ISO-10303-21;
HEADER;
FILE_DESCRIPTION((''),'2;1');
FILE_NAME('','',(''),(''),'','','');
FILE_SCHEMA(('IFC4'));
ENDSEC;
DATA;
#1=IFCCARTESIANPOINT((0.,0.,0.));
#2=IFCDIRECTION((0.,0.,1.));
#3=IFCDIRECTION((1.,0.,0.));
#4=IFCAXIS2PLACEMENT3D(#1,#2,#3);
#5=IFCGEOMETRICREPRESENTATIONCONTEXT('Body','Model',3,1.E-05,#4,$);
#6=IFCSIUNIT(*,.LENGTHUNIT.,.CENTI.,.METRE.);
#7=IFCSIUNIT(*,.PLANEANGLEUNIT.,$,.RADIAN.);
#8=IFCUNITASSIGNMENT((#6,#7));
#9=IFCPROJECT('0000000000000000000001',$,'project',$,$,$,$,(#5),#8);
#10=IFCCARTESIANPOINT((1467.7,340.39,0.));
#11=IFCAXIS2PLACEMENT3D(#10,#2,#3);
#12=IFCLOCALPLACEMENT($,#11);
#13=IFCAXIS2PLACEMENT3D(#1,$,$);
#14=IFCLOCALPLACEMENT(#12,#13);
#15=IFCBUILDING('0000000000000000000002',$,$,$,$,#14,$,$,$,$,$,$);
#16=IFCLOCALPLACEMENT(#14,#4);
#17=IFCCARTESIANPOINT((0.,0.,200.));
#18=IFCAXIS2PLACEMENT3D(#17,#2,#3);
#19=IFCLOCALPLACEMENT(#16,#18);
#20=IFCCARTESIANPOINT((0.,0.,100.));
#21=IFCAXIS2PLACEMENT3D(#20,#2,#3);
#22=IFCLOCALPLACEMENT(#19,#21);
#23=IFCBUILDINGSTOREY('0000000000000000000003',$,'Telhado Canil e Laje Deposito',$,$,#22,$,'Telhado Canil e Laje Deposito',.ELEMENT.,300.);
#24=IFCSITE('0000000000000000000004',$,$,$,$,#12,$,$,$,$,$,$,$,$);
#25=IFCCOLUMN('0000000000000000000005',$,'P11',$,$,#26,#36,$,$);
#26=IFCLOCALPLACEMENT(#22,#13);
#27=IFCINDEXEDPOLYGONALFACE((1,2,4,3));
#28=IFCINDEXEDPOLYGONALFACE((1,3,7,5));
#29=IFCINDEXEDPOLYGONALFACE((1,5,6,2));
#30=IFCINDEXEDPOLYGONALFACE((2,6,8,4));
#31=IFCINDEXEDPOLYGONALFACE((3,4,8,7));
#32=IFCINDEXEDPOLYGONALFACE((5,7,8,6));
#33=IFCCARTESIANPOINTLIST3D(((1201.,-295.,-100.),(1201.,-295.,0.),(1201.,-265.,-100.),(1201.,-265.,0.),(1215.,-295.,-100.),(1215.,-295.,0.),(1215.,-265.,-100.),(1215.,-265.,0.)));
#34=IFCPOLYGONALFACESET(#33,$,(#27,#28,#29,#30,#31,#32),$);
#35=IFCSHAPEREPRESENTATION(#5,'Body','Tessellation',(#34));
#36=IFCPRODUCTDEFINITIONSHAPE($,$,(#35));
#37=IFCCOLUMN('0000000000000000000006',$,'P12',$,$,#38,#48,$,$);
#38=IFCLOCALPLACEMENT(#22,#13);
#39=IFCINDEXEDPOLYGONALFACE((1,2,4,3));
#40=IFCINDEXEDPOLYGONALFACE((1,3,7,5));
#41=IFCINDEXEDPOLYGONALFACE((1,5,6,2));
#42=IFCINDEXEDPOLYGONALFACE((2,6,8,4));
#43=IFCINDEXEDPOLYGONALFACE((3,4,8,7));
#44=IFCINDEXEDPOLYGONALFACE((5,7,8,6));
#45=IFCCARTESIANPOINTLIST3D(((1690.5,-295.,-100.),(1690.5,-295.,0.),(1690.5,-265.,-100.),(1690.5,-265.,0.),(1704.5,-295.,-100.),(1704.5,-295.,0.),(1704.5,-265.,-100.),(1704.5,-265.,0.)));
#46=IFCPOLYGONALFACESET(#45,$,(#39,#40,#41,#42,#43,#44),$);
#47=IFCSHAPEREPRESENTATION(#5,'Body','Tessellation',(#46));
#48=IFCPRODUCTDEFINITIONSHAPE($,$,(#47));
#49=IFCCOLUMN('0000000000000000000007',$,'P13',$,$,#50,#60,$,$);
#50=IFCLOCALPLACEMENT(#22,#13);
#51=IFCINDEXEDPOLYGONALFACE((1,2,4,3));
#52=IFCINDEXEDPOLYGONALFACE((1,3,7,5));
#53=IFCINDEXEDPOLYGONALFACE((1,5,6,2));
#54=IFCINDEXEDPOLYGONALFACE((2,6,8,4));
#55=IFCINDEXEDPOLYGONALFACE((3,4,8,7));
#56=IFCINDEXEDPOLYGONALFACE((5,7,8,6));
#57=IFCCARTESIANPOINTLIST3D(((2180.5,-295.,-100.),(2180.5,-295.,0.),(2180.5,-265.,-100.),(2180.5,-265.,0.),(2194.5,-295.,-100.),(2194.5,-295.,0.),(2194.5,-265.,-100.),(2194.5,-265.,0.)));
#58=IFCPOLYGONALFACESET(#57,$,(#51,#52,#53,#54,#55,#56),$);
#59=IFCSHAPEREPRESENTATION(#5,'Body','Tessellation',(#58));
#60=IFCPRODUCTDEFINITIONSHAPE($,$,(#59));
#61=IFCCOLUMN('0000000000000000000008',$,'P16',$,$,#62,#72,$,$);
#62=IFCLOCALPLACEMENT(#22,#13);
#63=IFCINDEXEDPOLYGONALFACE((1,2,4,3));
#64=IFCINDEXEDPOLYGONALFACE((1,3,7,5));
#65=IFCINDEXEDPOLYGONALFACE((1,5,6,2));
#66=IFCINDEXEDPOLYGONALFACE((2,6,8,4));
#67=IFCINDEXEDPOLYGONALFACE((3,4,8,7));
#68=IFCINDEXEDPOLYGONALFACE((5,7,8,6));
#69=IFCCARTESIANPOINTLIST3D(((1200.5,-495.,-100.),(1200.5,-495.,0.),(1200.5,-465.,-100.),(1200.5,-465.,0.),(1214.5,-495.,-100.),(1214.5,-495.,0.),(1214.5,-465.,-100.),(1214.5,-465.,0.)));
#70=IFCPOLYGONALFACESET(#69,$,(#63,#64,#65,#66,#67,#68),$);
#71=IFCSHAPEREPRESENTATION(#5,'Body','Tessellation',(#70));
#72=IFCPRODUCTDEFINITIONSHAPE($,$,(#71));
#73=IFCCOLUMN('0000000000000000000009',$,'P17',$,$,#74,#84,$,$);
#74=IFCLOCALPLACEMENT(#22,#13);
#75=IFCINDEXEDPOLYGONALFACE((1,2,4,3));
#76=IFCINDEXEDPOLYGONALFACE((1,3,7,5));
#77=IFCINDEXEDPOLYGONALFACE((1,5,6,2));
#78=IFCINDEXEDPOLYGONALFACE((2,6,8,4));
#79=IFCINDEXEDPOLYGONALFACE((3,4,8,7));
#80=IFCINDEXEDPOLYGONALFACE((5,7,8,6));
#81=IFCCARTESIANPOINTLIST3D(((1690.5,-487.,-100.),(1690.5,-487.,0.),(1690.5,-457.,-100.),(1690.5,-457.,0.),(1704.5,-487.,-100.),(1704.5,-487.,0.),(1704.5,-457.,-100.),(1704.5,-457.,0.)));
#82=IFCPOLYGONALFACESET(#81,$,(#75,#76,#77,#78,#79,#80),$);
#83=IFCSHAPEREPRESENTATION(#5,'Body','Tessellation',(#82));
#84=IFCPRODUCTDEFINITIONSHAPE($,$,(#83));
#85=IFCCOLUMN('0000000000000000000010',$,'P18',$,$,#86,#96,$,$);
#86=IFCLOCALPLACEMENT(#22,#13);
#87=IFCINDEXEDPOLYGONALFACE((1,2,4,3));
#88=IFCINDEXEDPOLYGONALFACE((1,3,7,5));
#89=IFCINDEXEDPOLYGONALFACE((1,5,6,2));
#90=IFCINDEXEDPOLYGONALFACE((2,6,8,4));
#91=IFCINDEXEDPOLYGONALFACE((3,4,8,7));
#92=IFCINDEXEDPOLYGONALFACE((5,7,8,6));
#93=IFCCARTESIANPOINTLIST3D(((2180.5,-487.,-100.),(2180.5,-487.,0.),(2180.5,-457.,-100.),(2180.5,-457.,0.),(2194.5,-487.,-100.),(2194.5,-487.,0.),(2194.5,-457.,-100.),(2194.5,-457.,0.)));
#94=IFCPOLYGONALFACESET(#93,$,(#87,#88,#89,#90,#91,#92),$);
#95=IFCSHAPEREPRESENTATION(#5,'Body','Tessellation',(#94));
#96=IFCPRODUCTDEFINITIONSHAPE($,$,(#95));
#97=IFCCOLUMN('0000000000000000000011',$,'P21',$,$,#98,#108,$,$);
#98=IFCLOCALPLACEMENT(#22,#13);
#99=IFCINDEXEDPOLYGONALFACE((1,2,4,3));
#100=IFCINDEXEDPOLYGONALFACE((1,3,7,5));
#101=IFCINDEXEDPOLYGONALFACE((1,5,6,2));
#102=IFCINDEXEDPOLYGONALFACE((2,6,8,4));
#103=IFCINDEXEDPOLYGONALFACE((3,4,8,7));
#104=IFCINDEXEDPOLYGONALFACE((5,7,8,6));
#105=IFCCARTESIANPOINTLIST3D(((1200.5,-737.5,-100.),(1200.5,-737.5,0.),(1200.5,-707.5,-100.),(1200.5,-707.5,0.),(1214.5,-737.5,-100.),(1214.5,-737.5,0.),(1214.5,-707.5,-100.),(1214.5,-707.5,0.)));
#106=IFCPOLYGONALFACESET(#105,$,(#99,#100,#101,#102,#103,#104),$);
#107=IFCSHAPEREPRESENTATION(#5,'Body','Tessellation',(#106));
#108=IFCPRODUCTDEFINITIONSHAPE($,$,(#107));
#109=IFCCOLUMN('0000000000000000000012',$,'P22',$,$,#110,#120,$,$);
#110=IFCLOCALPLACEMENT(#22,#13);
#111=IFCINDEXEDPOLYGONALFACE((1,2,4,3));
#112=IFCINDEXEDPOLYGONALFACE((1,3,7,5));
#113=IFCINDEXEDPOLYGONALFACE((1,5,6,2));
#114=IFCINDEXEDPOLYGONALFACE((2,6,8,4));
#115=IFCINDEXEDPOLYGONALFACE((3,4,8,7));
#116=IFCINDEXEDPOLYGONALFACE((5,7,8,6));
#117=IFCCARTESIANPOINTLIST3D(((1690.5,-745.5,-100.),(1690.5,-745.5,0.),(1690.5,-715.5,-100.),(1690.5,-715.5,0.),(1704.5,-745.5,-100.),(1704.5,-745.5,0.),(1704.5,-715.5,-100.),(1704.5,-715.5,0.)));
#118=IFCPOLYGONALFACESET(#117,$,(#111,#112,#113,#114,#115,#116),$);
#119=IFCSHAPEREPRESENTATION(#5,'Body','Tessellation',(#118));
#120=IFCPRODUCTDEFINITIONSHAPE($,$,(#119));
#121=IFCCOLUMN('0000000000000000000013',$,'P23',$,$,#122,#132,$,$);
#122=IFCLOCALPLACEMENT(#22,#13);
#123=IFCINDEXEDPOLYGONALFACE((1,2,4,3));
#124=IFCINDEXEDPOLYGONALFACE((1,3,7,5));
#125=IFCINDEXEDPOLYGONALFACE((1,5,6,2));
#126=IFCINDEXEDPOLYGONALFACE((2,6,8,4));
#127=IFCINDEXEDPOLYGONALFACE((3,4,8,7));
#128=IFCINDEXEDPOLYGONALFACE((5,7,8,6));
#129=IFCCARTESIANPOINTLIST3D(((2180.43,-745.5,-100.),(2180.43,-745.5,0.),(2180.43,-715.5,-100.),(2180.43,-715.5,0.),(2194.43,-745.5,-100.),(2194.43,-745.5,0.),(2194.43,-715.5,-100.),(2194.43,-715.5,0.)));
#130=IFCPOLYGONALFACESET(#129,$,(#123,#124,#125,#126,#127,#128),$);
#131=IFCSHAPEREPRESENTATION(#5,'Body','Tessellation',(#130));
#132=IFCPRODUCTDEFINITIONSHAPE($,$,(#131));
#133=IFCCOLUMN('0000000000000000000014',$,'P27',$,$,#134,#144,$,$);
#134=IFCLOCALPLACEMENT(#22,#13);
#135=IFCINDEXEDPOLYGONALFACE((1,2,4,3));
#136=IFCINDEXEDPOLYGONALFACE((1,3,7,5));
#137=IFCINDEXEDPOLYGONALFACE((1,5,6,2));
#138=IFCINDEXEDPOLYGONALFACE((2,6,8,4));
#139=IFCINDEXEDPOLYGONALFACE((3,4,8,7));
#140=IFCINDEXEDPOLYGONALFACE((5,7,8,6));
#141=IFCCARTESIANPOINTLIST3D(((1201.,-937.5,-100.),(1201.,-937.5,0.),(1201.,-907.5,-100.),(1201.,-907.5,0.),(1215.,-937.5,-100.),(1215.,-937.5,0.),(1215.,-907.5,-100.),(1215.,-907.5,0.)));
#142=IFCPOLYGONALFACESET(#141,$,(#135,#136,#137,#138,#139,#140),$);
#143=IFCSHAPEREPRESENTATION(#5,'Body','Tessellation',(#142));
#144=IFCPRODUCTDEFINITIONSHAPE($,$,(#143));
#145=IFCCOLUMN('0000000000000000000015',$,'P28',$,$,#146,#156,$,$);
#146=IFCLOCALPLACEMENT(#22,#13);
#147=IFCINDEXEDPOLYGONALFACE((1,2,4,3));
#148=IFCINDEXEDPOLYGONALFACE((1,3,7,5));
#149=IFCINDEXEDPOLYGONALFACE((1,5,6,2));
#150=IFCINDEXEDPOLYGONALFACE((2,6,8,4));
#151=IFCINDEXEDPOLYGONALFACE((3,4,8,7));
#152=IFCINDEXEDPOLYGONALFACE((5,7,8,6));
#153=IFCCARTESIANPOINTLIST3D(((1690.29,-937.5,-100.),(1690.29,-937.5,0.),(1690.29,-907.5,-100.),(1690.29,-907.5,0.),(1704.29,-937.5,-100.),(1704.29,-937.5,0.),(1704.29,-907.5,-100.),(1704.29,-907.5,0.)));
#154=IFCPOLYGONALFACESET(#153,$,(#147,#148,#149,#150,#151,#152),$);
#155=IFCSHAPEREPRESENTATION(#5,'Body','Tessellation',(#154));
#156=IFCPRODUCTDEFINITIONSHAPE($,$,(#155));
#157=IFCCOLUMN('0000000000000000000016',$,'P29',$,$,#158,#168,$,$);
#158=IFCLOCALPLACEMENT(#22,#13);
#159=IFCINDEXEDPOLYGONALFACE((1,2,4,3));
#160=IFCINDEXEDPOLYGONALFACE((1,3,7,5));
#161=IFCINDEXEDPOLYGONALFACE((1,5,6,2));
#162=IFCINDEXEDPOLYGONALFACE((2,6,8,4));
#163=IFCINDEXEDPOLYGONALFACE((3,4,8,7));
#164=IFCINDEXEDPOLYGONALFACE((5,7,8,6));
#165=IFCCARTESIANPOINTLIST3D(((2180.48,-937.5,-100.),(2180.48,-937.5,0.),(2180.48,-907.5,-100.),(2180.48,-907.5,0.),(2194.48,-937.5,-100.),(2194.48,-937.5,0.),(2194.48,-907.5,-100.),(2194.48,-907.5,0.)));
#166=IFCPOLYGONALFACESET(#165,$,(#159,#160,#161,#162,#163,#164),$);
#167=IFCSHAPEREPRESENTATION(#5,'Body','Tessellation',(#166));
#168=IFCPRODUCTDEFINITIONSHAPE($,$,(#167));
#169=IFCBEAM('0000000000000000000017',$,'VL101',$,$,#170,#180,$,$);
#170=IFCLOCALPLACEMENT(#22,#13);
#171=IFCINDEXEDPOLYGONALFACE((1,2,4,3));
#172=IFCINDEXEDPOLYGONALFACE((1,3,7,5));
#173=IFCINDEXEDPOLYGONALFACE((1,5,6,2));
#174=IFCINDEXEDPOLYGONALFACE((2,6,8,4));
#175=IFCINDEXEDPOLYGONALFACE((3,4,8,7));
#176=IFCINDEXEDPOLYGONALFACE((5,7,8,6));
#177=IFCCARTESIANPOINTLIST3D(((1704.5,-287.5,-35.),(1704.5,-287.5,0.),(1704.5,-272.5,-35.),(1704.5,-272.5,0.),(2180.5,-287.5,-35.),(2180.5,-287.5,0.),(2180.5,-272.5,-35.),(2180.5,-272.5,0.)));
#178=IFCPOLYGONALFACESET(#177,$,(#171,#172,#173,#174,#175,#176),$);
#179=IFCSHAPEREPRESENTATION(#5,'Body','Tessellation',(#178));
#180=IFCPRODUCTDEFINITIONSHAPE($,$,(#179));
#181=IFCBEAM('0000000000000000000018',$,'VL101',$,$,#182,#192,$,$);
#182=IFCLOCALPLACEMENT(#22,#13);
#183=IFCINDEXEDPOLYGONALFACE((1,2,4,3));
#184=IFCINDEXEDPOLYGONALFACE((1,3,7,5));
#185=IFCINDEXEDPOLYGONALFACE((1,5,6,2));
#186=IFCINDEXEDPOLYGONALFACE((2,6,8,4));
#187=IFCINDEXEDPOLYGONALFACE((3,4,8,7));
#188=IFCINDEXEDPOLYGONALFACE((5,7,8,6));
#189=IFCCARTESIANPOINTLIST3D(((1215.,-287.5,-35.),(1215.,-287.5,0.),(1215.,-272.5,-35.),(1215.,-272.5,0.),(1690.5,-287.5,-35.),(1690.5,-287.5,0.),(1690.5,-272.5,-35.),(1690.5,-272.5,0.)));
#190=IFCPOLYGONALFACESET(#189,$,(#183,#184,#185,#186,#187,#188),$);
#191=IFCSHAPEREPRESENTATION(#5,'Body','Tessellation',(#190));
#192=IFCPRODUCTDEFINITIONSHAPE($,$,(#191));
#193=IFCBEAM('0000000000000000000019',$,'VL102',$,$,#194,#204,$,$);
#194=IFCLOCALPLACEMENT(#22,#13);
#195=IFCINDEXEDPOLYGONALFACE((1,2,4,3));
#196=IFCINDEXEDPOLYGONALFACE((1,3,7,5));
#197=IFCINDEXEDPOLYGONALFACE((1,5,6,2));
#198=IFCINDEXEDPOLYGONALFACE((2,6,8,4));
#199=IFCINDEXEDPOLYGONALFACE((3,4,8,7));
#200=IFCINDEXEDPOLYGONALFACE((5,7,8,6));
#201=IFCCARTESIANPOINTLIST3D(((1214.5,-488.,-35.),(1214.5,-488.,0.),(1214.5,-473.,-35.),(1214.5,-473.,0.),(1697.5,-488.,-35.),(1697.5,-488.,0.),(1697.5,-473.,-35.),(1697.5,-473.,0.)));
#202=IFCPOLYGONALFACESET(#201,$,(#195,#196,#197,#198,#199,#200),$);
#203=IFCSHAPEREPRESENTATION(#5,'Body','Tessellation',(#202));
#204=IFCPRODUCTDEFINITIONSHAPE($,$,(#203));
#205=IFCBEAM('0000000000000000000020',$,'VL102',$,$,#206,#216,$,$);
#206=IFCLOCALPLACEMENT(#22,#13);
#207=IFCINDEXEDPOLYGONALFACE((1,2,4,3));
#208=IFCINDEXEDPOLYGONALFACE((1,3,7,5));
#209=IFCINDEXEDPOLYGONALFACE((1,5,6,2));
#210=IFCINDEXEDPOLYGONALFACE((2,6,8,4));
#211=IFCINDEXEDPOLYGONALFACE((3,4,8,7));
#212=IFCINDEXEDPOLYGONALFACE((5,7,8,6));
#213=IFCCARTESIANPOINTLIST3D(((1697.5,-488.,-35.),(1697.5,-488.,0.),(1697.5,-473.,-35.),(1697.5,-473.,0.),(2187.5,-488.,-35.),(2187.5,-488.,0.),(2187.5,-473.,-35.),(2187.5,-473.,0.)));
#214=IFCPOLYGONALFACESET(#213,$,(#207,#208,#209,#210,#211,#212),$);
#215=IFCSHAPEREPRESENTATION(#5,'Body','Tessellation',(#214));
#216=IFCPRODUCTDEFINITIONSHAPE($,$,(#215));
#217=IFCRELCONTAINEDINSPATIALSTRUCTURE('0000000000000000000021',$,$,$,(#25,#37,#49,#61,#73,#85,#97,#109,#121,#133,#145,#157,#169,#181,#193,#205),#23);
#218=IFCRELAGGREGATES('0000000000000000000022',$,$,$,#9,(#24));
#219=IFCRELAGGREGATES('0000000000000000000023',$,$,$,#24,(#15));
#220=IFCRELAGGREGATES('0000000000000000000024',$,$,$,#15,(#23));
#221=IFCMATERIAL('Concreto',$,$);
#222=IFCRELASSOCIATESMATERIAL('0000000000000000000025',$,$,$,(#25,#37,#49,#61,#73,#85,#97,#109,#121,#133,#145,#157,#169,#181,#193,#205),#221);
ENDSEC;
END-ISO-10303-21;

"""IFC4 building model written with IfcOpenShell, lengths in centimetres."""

from ifc_helpers import new_model, si_unit, frame, origin, origin_with_axes, origin_2d_with_axis, place, context, project, spatial, rectangle, extrude, material, element, save


model = new_model("IFC4")

# Units and contexts
model_context = context("Model", 3, precision=1e-05, world=origin_with_axes(), identifier="Body")
ifc_project = project(units=[si_unit("LENGTHUNIT", "METRE", prefix="CENTI"), si_unit("PLANEANGLEUNIT", "RADIAN")], contexts=[model_context])

# Site, building, storey
site_placement = place(None, frame((1467.7, 340.39, 0.0), z_axis=(0.0, 0.0, 1.0), x_axis=(1.0, 0.0, 0.0)))
site = spatial("IfcSite", under=ifc_project, at=site_placement)
building_placement = place(site_placement, origin())
building = spatial("IfcBuilding", under=site, at=building_placement)
placement_1 = place(building_placement, origin_with_axes())
placement_2 = place(placement_1, frame((0.0, 0.0, 200.0), z_axis=(0.0, 0.0, 1.0), x_axis=(1.0, 0.0, 0.0)))
storey_placement = place(placement_2, frame((0.0, 0.0, 100.0), z_axis=(0.0, 0.0, 1.0), x_axis=(1.0, 0.0, 0.0)))
storey = spatial("IfcBuildingStorey", under=building, at=storey_placement, Name="Telhado Canil e Laje Deposito", LongName="Telhado Canil e Laje Deposito", CompositionType="ELEMENT", Elevation=300.0)

# Columns
ifc_material = material(Name="Concreto")
for number, where, z_axis, x_axis, name in (
    (1, (1208.0, -280.0, 0.0), (0.0, 0.0, 1.0), (1.0, 0.0, 0.0), "P11"),
    (2, (1697.5, -280.0, 0.0), (0.0, 0.0, 1.0), (1.0, 0.0, 0.0), "P12"),
    (3, (2187.5, -280.0, 0.0), (0.0, 0.0, 1.0), (1.0, 0.0, 0.0), "P13"),
    (4, (1207.5, -480.0, 0.0), (0.0, 0.0, 1.0), (1.0, 0.0, 0.0), "P16"),
):
    element("IfcColumn", number, at=place(storey_placement, frame(where, z_axis=z_axis, x_axis=x_axis)), inside=storey, material=ifc_material, Name=name, context=model_context, shape_type="SolidModel", body=[
        extrude(rectangle(XDim=14.0, YDim=30.0, at=origin_2d_with_axis()), origin_with_axes(), (0.0, 0.0, -1.0), 100.0),
    ])
for number, where, z_axis, x_axis, name in (
    (5, (1697.5, -472.0, 0.0), (0.0, 0.0, 1.0), (1.0, 0.0, 0.0), "P17"),
    (6, (2187.5, -472.0, 0.0), (0.0, 0.0, 1.0), (1.0, 0.0, 0.0), "P18"),
):
    element("IfcColumn", number, at=place(storey_placement, frame(where, z_axis=z_axis, x_axis=x_axis)), inside=storey, material=ifc_material, Name=name, context=model_context, shape_type="SolidModel", body=[
        extrude(rectangle(XDim=14.0, YDim=30.0, at=origin_2d_with_axis()), frame((0.0, 0.0, 0.0), z_axis=(0.0, 0.0, 1.0), x_axis=(-1.0, 0.0, 0.0)), (0.0, 0.0, -1.0), 100.0),
    ])
column_1_placement = place(storey_placement, frame((1207.5, -722.5, 0.0), z_axis=(0.0, 0.0, 1.0), x_axis=(1.0, 0.0, 0.0)))
element("IfcColumn", 7, at=column_1_placement, inside=storey, material=ifc_material, Name="P21", context=model_context, shape_type="SolidModel", body=[
    extrude(rectangle(XDim=14.0, YDim=30.0, at=origin_2d_with_axis()), origin_with_axes(), (0.0, 0.0, -1.0), 100.0),
])
column_2_placement = place(storey_placement, frame((1697.5, -730.5, 0.0), z_axis=(0.0, 0.0, 1.0), x_axis=(1.0, 0.0, 0.0)))
element("IfcColumn", 8, at=column_2_placement, inside=storey, material=ifc_material, Name="P22", context=model_context, shape_type="SolidModel", body=[
    extrude(rectangle(XDim=14.0, YDim=30.0, at=origin_2d_with_axis()), frame((0.0, 0.0, 0.0), z_axis=(0.0, 0.0, 1.0), x_axis=(-1.0, 0.0, 0.0)), (0.0, 0.0, -1.0), 100.0),
])
for number, where, z_axis, x_axis, name in (
    (9, (2187.43, -730.5, 0.0), (0.0, 0.0, 1.0), (1.0, 0.0, 0.0), "P23"),
    (10, (1208.0, -922.5, 0.0), (0.0, 0.0, 1.0), (1.0, 0.0, 0.0), "P27"),
    (11, (1697.29, -922.5, 0.0), (0.0, 0.0, 1.0), (1.0, 0.0, 0.0), "P28"),
    (12, (2187.48, -922.5, 0.0), (0.0, 0.0, 1.0), (1.0, 0.0, 0.0), "P29"),
):
    element("IfcColumn", number, at=place(storey_placement, frame(where, z_axis=z_axis, x_axis=x_axis)), inside=storey, material=ifc_material, Name=name, context=model_context, shape_type="SolidModel", body=[
        extrude(rectangle(XDim=14.0, YDim=30.0, at=origin_2d_with_axis()), origin_with_axes(), (0.0, 0.0, -1.0), 100.0),
    ])

# Beams
beam_1_placement = place(storey_placement, frame((1942.5, -280.0, 0.0), z_axis=(0.0, 0.0, 1.0), x_axis=(1.0, 0.0, 0.0)))
element("IfcBeam", 13, at=beam_1_placement, inside=storey, material=ifc_material, Name="VL101", context=model_context, shape_type="SolidModel", body=[
    extrude(rectangle(XDim=15.0, YDim=35.0, at=origin_2d_with_axis()), frame((-238.0, 0.0, -17.5), z_axis=(1.0, 0.0, 0.0), x_axis=(0.0, 1.0, 0.0)), (0.0, 0.0, 1.0), 476.0),
])
beam_2_placement = place(storey_placement, frame((1452.75, -280.0, 0.0), z_axis=(0.0, 0.0, 1.0), x_axis=(1.0, 0.0, 0.0)))
element("IfcBeam", 14, at=beam_2_placement, inside=storey, material=ifc_material, Name="VL101", context=model_context, shape_type="SolidModel", body=[
    extrude(rectangle(XDim=15.0, YDim=35.0, at=origin_2d_with_axis()), frame((-237.75, 0.0, -17.5), z_axis=(1.0, 0.0, 0.0), x_axis=(0.0, 1.0, 0.0)), (0.0, 0.0, 1.0), 475.5),
])
beam_3_placement = place(storey_placement, frame((1456.0, -480.5, 0.0), z_axis=(0.0, 0.0, 1.0), x_axis=(1.0, 0.0, 0.0)))
element("IfcBeam", 15, at=beam_3_placement, inside=storey, material=ifc_material, Name="VL102", context=model_context, shape_type="SolidModel", body=[
    extrude(rectangle(XDim=15.0, YDim=35.0, at=origin_2d_with_axis()), frame((-241.5, 0.0, -17.5), z_axis=(1.0, 0.0, 0.0), x_axis=(0.0, 1.0, 0.0)), (0.0, 0.0, 1.0), 483.0),
])
beam_4_placement = place(storey_placement, frame((1942.5, -480.5, 0.0), z_axis=(0.0, 0.0, 1.0), x_axis=(1.0, 0.0, 0.0)))
element("IfcBeam", 16, at=beam_4_placement, inside=storey, material=ifc_material, Name="VL102", context=model_context, shape_type="SolidModel", body=[
    extrude(rectangle(XDim=15.0, YDim=35.0, at=origin_2d_with_axis()), frame((-245.0, 0.0, -17.5), z_axis=(1.0, 0.0, 0.0), x_axis=(0.0, 1.0, 0.0)), (0.0, 0.0, 1.0), 490.0),
])

save(model, "model.ifc")
